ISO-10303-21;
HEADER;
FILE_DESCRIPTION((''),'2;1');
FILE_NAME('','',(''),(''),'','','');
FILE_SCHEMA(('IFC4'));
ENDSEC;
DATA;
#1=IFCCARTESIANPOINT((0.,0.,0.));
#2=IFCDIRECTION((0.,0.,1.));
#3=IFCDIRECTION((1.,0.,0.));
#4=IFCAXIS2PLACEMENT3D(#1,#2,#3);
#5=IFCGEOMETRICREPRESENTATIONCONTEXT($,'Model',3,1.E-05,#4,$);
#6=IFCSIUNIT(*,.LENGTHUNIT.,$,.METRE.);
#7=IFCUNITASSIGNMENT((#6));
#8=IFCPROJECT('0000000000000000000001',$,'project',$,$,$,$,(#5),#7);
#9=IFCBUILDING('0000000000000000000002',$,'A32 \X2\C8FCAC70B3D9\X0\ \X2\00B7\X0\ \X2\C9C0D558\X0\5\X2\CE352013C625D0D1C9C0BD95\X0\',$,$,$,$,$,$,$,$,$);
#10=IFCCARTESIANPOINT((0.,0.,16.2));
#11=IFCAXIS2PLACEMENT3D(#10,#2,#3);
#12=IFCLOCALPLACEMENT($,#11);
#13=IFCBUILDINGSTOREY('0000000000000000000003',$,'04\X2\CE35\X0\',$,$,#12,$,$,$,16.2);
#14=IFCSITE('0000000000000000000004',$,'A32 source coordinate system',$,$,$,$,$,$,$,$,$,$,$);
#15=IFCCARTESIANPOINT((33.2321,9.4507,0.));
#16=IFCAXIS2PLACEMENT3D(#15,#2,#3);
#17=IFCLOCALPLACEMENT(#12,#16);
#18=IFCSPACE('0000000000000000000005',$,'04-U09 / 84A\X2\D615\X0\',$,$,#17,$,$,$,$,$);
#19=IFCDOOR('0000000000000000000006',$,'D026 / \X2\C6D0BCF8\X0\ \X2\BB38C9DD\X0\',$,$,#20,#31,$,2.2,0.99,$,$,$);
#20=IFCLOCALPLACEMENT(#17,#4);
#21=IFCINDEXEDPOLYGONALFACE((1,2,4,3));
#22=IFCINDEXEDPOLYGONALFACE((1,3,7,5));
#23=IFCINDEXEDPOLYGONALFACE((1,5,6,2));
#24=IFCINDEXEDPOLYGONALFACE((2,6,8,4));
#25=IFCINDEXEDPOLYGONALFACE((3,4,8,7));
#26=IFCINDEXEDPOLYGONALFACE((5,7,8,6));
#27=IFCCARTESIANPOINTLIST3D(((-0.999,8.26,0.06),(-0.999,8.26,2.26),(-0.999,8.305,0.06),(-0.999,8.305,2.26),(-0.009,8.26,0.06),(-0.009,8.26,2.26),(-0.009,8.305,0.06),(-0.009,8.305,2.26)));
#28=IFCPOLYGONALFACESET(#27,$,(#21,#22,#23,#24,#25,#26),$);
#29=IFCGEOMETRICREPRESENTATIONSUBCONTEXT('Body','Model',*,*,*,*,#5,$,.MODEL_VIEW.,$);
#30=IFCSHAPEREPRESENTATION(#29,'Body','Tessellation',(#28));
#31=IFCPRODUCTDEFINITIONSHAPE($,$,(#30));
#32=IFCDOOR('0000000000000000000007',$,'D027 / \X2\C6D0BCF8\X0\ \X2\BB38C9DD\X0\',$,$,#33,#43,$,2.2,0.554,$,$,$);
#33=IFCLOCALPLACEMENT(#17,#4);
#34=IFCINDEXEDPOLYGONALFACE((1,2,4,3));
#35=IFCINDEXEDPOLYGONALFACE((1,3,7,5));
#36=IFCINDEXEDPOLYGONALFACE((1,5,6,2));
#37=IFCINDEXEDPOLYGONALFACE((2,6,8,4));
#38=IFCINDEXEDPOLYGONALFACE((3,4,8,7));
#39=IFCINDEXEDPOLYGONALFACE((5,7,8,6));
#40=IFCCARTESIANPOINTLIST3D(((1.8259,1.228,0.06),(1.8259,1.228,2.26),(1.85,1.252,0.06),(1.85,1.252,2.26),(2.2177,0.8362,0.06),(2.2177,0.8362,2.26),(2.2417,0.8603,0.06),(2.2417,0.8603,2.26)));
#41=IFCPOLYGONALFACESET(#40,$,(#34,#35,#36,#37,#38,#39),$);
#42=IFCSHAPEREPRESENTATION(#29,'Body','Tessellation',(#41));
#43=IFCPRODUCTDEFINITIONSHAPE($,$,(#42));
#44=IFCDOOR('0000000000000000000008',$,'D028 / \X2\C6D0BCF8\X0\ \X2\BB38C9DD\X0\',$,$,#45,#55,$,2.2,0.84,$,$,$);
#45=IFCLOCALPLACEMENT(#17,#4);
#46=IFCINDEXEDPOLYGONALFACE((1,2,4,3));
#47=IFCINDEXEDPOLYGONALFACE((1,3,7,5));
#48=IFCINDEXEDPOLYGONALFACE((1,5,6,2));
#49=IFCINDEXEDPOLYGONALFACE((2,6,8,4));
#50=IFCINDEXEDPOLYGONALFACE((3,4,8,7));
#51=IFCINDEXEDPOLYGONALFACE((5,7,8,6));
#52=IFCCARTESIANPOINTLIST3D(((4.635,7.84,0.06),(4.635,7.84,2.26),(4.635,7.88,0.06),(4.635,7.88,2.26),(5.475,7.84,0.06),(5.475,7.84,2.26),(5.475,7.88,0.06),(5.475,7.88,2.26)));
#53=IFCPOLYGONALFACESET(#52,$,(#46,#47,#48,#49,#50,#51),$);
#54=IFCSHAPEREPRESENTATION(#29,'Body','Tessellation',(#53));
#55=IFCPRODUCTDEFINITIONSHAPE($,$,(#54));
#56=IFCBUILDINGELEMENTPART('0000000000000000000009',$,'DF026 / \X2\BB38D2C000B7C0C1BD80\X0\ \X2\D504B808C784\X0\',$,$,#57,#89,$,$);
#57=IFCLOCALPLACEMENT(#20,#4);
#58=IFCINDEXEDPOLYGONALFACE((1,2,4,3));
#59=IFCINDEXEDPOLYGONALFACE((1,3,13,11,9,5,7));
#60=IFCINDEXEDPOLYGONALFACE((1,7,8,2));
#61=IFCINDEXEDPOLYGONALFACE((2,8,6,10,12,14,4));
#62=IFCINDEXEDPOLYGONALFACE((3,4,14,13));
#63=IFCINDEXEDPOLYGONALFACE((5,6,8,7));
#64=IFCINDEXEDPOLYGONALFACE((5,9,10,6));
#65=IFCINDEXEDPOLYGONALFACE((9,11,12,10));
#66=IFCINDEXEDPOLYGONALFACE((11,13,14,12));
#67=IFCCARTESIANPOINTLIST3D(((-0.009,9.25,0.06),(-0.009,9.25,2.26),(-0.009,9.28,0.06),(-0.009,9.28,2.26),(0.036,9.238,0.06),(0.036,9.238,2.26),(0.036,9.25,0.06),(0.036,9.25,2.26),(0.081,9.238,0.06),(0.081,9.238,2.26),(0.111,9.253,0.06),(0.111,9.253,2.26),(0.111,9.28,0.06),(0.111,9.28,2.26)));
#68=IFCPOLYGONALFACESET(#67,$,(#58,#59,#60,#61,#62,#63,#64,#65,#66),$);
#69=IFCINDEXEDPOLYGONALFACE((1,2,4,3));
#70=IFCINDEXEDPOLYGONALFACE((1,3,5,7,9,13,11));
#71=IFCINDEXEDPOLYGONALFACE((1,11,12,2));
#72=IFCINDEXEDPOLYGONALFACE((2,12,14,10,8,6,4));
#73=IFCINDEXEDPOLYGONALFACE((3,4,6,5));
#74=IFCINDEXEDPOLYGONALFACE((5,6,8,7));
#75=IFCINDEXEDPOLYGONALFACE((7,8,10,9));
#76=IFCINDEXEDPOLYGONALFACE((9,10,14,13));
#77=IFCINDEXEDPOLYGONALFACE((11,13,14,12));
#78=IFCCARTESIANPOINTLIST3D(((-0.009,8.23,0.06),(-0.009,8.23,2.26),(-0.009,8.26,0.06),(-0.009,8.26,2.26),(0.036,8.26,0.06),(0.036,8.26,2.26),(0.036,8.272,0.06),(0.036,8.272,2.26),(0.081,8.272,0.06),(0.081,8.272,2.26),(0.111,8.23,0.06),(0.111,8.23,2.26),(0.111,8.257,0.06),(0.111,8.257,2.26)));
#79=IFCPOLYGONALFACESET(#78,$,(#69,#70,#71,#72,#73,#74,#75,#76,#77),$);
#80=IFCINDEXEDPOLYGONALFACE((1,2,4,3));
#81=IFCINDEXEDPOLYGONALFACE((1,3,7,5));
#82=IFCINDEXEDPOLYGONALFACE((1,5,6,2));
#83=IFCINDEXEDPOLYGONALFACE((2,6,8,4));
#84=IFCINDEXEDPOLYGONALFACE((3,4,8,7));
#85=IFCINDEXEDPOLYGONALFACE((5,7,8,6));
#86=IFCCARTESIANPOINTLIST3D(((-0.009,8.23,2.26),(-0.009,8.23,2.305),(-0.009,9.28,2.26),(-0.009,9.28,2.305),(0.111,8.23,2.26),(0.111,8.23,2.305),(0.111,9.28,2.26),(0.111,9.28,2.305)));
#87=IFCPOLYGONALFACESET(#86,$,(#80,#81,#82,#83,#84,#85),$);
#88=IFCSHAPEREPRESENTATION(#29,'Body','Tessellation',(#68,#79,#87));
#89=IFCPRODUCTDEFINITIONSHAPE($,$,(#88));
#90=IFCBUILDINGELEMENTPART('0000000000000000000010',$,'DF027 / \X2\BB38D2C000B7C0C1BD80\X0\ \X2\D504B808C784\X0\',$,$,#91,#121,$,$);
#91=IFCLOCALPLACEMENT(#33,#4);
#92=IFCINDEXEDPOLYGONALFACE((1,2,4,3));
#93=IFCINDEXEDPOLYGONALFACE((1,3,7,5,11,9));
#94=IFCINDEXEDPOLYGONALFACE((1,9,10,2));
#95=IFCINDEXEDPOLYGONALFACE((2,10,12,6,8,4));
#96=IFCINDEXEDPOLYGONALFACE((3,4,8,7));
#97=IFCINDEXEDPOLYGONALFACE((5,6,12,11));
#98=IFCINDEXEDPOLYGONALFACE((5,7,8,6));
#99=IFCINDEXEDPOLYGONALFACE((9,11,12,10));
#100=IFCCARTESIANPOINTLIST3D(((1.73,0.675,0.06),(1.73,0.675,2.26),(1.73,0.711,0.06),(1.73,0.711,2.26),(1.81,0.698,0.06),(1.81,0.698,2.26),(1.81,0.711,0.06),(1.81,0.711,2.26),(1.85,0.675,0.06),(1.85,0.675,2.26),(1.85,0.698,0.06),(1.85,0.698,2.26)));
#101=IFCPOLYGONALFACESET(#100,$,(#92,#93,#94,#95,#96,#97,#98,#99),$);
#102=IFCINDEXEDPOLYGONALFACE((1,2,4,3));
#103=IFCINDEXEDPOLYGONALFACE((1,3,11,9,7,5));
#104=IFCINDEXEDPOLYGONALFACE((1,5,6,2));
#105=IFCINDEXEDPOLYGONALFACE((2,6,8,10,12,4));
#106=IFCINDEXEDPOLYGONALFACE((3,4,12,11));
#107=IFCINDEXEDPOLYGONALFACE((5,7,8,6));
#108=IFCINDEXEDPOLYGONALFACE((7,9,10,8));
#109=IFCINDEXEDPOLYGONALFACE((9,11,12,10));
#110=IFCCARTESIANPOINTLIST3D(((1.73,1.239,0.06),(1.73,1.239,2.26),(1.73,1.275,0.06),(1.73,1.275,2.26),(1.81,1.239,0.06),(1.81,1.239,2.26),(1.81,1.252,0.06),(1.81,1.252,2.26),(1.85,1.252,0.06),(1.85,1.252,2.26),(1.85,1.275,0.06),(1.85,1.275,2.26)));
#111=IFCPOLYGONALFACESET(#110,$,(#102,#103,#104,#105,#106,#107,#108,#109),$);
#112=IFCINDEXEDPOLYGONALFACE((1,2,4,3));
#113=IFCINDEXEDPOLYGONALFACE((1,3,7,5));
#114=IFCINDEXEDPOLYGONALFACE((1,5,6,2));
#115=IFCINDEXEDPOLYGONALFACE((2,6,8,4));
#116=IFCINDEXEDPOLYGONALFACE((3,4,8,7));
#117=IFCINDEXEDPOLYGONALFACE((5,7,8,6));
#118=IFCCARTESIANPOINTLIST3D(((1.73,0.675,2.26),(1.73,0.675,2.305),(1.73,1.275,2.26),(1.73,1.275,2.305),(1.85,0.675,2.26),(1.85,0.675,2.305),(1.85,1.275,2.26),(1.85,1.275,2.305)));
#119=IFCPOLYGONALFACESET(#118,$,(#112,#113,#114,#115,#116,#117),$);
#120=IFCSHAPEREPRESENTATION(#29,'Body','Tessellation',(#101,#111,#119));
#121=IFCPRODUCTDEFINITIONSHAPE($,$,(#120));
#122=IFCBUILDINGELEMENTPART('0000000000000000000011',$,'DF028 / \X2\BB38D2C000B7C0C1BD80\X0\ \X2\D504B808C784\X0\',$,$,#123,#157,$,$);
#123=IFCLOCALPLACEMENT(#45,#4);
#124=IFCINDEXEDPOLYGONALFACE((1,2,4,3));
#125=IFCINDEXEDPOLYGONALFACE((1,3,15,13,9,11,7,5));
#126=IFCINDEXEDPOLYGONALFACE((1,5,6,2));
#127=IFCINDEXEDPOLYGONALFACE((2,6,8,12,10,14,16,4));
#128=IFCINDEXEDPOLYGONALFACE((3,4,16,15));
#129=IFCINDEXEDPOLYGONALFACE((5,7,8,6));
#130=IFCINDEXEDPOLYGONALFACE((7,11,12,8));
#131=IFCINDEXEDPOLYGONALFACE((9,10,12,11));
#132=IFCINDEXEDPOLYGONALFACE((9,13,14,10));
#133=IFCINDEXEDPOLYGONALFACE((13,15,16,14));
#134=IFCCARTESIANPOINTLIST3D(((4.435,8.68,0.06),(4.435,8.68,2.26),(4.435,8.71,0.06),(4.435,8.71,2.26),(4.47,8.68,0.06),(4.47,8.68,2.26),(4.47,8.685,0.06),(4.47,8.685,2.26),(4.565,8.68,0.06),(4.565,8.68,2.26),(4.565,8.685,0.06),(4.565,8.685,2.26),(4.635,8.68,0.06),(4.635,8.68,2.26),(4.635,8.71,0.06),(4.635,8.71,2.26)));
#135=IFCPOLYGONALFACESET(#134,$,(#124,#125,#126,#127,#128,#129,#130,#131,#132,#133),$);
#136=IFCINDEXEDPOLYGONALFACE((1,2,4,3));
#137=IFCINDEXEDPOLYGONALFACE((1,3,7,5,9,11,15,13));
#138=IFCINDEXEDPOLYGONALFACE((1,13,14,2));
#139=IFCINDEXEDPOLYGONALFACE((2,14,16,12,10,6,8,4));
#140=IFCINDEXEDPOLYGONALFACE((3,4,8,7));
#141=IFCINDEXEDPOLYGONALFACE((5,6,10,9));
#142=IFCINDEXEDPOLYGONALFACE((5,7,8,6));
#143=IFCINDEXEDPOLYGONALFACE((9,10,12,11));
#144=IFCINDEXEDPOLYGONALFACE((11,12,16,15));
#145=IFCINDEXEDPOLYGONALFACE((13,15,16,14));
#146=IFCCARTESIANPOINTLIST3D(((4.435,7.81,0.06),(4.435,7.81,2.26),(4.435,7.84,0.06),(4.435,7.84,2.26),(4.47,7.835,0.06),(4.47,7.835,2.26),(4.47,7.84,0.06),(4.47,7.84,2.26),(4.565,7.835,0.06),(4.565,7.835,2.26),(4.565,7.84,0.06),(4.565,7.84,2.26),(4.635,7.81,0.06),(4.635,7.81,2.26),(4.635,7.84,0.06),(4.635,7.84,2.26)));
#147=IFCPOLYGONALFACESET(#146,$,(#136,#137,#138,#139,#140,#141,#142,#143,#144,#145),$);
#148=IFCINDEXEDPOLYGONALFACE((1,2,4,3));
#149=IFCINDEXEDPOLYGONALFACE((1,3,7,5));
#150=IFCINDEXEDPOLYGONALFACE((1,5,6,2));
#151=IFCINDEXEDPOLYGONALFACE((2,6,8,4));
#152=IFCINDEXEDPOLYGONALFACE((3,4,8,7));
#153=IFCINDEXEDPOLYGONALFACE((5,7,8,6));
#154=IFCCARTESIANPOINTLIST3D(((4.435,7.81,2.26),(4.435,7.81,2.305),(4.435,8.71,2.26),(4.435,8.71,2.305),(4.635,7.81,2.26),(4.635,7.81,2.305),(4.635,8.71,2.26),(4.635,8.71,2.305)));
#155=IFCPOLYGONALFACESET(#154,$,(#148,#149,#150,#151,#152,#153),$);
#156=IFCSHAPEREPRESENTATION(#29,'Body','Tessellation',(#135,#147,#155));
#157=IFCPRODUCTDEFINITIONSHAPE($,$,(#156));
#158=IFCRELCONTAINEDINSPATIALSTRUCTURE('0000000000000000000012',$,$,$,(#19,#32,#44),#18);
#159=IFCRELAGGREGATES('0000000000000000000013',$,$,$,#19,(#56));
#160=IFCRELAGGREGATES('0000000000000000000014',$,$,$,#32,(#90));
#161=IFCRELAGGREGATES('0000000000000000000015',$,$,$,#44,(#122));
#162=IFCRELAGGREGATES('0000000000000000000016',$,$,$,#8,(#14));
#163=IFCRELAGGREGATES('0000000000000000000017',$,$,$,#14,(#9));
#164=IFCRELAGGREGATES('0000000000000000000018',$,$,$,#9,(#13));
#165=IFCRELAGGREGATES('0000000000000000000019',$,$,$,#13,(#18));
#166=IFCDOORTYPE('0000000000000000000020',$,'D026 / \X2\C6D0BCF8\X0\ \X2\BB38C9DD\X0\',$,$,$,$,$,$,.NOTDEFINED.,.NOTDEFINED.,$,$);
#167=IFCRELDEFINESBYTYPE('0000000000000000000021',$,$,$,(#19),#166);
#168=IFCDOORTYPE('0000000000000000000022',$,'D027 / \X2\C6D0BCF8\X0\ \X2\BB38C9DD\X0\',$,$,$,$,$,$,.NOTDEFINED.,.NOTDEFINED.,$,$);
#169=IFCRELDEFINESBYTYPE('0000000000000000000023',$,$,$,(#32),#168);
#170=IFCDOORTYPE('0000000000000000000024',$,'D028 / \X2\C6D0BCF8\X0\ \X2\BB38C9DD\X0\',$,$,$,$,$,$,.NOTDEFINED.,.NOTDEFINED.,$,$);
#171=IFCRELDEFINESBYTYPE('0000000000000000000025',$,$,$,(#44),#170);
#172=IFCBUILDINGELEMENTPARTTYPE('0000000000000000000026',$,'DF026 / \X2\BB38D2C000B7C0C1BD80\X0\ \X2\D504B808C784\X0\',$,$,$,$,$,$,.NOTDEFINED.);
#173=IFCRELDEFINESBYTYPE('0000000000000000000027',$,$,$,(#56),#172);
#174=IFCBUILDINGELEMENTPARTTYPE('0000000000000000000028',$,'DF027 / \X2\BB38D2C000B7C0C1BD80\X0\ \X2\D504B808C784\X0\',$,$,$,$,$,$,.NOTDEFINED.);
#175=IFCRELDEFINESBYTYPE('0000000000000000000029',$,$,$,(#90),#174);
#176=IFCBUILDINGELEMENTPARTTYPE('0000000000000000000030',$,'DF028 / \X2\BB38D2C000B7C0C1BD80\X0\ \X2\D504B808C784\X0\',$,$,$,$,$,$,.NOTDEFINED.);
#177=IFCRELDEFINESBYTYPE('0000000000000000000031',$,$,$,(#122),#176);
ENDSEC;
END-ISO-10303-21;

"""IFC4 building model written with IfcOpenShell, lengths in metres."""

from ifc_helpers import new_model, si_unit, frame, origin, origin_with_axes, place, context, subcontext, project, spatial, polyline, outline, extrude, source, transform, mapped, type_object, type_shapes, element, aggregate, save


model = new_model("IFC4")

# Units and contexts
model_context = context("Model", 3, precision=1e-05, world=origin_with_axes())
body_context = subcontext(model_context, "Body", "Model", "MODEL_VIEW")
ifc_project = project(units=[si_unit("LENGTHUNIT", "METRE")], contexts=[model_context])

# Site, building, storey, space
site = spatial("IfcSite", under=ifc_project, Name="A32 source coordinate system")
building = spatial("IfcBuilding", under=site, Name="A32 주거동 · 지하5층–옥탑지붕")
storey_placement = place(None, frame((0.0, 0.0, 16.2), z_axis=(0.0, 0.0, 1.0), x_axis=(1.0, 0.0, 0.0)))
storey = spatial("IfcBuildingStorey", under=building, at=storey_placement, Name="04층", Elevation=16.2)
space_1_placement = place(storey_placement, frame((33.2321, 9.4507, 0.0), z_axis=(0.0, 0.0, 1.0), x_axis=(1.0, 0.0, 0.0)))
space_1 = spatial("IfcSpace", under=storey, at=space_1_placement, Name="04-U09 / 84A형")

# Doors
door_type_1 = type_object("IfcDoorType", Name="D026 / 원본 문짝", OperationType="NOTDEFINED", PredefinedType="NOTDEFINED")
shared_shape_1 = source(origin(), body_context, "Body", "SweptSolid", [
    extrude(outline(polyline([(-0.009, 8.26), (-0.999, 8.26), (-0.999, 8.305), (-0.009, 8.305), (-0.009, 8.26)])), frame((0.0, 0.0, 0.06)), (0.0, 0.0, 1.0), 2.2),
])
type_shapes(door_type_1, [shared_shape_1])
door_1_placement = place(space_1_placement, origin_with_axes())
door_1 = element("IfcDoor", 1, at=door_1_placement, inside=space_1, type_object=door_type_1, Name="D026 / 원본 문짝", OverallHeight=2.2, OverallWidth=0.99, context=body_context, shape_type="MappedRepresentation", body=[
    mapped(shared_shape_1, transform((0.0, 0.0, 0.0), scale=1.0)),
])
door_type_2 = type_object("IfcDoorType", Name="D027 / 원본 문짝", OperationType="NOTDEFINED", PredefinedType="NOTDEFINED")
shared_shape_2 = source(origin(), body_context, "Body", "SweptSolid", [
    extrude(outline(polyline([(1.85, 1.252), (2.2417, 0.8603), (2.2177, 0.8362), (1.8259, 1.228), (1.85, 1.252)])), frame((0.0, 0.0, 0.06)), (0.0, 0.0, 1.0), 2.2),
])
type_shapes(door_type_2, [shared_shape_2])
door_2_placement = place(space_1_placement, origin_with_axes())
door_2 = element("IfcDoor", 2, at=door_2_placement, inside=space_1, type_object=door_type_2, Name="D027 / 원본 문짝", OverallHeight=2.2, OverallWidth=0.554, context=body_context, shape_type="MappedRepresentation", body=[
    mapped(shared_shape_2, transform((0.0, 0.0, 0.0), scale=1.0)),
])
door_type_3 = type_object("IfcDoorType", Name="D028 / 원본 문짝", OperationType="NOTDEFINED", PredefinedType="NOTDEFINED")
shared_shape_3 = source(origin(), body_context, "Body", "SweptSolid", [
    extrude(outline(polyline([(5.475, 7.88), (5.475, 7.84), (4.635, 7.84), (4.635, 7.88), (5.475, 7.88)])), frame((0.0, 0.0, 0.06)), (0.0, 0.0, 1.0), 2.2),
])
type_shapes(door_type_3, [shared_shape_3])
door_3_placement = place(space_1_placement, origin_with_axes())
door_3 = element("IfcDoor", 3, at=door_3_placement, inside=space_1, type_object=door_type_3, Name="D028 / 원본 문짝", OverallHeight=2.2, OverallWidth=0.84, context=body_context, shape_type="MappedRepresentation", body=[
    mapped(shared_shape_3, transform((0.0, 0.0, 0.0), scale=1.0)),
])

# Building element parts
building_element_part_type_1 = type_object("IfcBuildingElementPartType", Name="DF026 / 문틀·상부 프레임", PredefinedType="NOTDEFINED")
shared_shape_4 = source(origin(), body_context, "Body", "SweptSolid", [
    extrude(outline(polyline([(0.111, 9.28), (0.111, 9.253), (0.081, 9.238), (0.036, 9.238), (0.036, 9.25), (-0.009, 9.25), (-0.009, 9.28), (0.111, 9.28)])), frame((0.0, 0.0, 0.06)), (0.0, 0.0, 1.0), 2.2),
    extrude(outline(polyline([(-0.009, 8.26), (0.036, 8.26), (0.036, 8.272), (0.081, 8.272), (0.111, 8.257), (0.111, 8.23), (-0.009, 8.23), (-0.009, 8.26)])), frame((0.0, 0.0, 0.06)), (0.0, 0.0, 1.0), 2.2),
    extrude(outline(polyline([(-0.009, 8.23), (-0.009, 9.28), (0.111, 9.28), (0.111, 8.23), (-0.009, 8.23)])), frame((0.0, 0.0, 2.26)), (0.0, 0.0, 1.0), 0.045),
])
type_shapes(building_element_part_type_1, [shared_shape_4])
building_element_part_1_placement = place(door_1_placement, origin_with_axes())
building_element_part_1 = element("IfcBuildingElementPart", 4, at=building_element_part_1_placement, type_object=building_element_part_type_1, Name="DF026 / 문틀·상부 프레임", context=body_context, shape_type="MappedRepresentation", body=[
    mapped(shared_shape_4, transform((0.0, 0.0, 0.0), scale=1.0)),
])
aggregate(door_1, [building_element_part_1])
building_element_part_type_2 = type_object("IfcBuildingElementPartType", Name="DF027 / 문틀·상부 프레임", PredefinedType="NOTDEFINED")
shared_shape_5 = source(origin(), body_context, "Body", "SweptSolid", [
    extrude(outline(polyline([(1.73, 0.711), (1.81, 0.711), (1.81, 0.698), (1.85, 0.698), (1.85, 0.675), (1.73, 0.675), (1.73, 0.711)])), frame((0.0, 0.0, 0.06)), (0.0, 0.0, 1.0), 2.2),
    extrude(outline(polyline([(1.85, 1.275), (1.85, 1.252), (1.81, 1.252), (1.81, 1.239), (1.73, 1.239), (1.73, 1.275), (1.85, 1.275)])), frame((0.0, 0.0, 0.06)), (0.0, 0.0, 1.0), 2.2),
    extrude(outline(polyline([(1.73, 0.675), (1.73, 1.275), (1.85, 1.275), (1.85, 0.675), (1.73, 0.675)])), frame((0.0, 0.0, 2.26)), (0.0, 0.0, 1.0), 0.045),
])
type_shapes(building_element_part_type_2, [shared_shape_5])
building_element_part_2_placement = place(door_2_placement, origin_with_axes())
building_element_part_2 = element("IfcBuildingElementPart", 5, at=building_element_part_2_placement, type_object=building_element_part_type_2, Name="DF027 / 문틀·상부 프레임", context=body_context, shape_type="MappedRepresentation", body=[
    mapped(shared_shape_5, transform((0.0, 0.0, 0.0), scale=1.0)),
])
aggregate(door_2, [building_element_part_2])
building_element_part_type_3 = type_object("IfcBuildingElementPartType", Name="DF028 / 문틀·상부 프레임", PredefinedType="NOTDEFINED")
shared_shape_6 = source(origin(), body_context, "Body", "SweptSolid", [
    extrude(outline(polyline([(4.635, 8.68), (4.565, 8.68), (4.565, 8.685), (4.47, 8.685), (4.47, 8.68), (4.435, 8.68), (4.435, 8.71), (4.635, 8.71), (4.635, 8.68)])), frame((0.0, 0.0, 0.06)), (0.0, 0.0, 1.0), 2.2),
    extrude(outline(polyline([(4.435, 7.81), (4.435, 7.84), (4.47, 7.84), (4.47, 7.835), (4.565, 7.835), (4.565, 7.84), (4.635, 7.84), (4.635, 7.81), (4.435, 7.81)])), frame((0.0, 0.0, 0.06)), (0.0, 0.0, 1.0), 2.2),
    extrude(outline(polyline([(4.435, 7.81), (4.435, 8.71), (4.635, 8.71), (4.635, 7.81), (4.435, 7.81)])), frame((0.0, 0.0, 2.26)), (0.0, 0.0, 1.0), 0.045),
])
type_shapes(building_element_part_type_3, [shared_shape_6])
building_element_part_3_placement = place(door_3_placement, origin_with_axes())
building_element_part_3 = element("IfcBuildingElementPart", 6, at=building_element_part_3_placement, type_object=building_element_part_type_3, Name="DF028 / 문틀·상부 프레임", context=body_context, shape_type="MappedRepresentation", body=[
    mapped(shared_shape_6, transform((0.0, 0.0, 0.0), scale=1.0)),
])
aggregate(door_3, [building_element_part_3])

save(model, "model.ifc")
